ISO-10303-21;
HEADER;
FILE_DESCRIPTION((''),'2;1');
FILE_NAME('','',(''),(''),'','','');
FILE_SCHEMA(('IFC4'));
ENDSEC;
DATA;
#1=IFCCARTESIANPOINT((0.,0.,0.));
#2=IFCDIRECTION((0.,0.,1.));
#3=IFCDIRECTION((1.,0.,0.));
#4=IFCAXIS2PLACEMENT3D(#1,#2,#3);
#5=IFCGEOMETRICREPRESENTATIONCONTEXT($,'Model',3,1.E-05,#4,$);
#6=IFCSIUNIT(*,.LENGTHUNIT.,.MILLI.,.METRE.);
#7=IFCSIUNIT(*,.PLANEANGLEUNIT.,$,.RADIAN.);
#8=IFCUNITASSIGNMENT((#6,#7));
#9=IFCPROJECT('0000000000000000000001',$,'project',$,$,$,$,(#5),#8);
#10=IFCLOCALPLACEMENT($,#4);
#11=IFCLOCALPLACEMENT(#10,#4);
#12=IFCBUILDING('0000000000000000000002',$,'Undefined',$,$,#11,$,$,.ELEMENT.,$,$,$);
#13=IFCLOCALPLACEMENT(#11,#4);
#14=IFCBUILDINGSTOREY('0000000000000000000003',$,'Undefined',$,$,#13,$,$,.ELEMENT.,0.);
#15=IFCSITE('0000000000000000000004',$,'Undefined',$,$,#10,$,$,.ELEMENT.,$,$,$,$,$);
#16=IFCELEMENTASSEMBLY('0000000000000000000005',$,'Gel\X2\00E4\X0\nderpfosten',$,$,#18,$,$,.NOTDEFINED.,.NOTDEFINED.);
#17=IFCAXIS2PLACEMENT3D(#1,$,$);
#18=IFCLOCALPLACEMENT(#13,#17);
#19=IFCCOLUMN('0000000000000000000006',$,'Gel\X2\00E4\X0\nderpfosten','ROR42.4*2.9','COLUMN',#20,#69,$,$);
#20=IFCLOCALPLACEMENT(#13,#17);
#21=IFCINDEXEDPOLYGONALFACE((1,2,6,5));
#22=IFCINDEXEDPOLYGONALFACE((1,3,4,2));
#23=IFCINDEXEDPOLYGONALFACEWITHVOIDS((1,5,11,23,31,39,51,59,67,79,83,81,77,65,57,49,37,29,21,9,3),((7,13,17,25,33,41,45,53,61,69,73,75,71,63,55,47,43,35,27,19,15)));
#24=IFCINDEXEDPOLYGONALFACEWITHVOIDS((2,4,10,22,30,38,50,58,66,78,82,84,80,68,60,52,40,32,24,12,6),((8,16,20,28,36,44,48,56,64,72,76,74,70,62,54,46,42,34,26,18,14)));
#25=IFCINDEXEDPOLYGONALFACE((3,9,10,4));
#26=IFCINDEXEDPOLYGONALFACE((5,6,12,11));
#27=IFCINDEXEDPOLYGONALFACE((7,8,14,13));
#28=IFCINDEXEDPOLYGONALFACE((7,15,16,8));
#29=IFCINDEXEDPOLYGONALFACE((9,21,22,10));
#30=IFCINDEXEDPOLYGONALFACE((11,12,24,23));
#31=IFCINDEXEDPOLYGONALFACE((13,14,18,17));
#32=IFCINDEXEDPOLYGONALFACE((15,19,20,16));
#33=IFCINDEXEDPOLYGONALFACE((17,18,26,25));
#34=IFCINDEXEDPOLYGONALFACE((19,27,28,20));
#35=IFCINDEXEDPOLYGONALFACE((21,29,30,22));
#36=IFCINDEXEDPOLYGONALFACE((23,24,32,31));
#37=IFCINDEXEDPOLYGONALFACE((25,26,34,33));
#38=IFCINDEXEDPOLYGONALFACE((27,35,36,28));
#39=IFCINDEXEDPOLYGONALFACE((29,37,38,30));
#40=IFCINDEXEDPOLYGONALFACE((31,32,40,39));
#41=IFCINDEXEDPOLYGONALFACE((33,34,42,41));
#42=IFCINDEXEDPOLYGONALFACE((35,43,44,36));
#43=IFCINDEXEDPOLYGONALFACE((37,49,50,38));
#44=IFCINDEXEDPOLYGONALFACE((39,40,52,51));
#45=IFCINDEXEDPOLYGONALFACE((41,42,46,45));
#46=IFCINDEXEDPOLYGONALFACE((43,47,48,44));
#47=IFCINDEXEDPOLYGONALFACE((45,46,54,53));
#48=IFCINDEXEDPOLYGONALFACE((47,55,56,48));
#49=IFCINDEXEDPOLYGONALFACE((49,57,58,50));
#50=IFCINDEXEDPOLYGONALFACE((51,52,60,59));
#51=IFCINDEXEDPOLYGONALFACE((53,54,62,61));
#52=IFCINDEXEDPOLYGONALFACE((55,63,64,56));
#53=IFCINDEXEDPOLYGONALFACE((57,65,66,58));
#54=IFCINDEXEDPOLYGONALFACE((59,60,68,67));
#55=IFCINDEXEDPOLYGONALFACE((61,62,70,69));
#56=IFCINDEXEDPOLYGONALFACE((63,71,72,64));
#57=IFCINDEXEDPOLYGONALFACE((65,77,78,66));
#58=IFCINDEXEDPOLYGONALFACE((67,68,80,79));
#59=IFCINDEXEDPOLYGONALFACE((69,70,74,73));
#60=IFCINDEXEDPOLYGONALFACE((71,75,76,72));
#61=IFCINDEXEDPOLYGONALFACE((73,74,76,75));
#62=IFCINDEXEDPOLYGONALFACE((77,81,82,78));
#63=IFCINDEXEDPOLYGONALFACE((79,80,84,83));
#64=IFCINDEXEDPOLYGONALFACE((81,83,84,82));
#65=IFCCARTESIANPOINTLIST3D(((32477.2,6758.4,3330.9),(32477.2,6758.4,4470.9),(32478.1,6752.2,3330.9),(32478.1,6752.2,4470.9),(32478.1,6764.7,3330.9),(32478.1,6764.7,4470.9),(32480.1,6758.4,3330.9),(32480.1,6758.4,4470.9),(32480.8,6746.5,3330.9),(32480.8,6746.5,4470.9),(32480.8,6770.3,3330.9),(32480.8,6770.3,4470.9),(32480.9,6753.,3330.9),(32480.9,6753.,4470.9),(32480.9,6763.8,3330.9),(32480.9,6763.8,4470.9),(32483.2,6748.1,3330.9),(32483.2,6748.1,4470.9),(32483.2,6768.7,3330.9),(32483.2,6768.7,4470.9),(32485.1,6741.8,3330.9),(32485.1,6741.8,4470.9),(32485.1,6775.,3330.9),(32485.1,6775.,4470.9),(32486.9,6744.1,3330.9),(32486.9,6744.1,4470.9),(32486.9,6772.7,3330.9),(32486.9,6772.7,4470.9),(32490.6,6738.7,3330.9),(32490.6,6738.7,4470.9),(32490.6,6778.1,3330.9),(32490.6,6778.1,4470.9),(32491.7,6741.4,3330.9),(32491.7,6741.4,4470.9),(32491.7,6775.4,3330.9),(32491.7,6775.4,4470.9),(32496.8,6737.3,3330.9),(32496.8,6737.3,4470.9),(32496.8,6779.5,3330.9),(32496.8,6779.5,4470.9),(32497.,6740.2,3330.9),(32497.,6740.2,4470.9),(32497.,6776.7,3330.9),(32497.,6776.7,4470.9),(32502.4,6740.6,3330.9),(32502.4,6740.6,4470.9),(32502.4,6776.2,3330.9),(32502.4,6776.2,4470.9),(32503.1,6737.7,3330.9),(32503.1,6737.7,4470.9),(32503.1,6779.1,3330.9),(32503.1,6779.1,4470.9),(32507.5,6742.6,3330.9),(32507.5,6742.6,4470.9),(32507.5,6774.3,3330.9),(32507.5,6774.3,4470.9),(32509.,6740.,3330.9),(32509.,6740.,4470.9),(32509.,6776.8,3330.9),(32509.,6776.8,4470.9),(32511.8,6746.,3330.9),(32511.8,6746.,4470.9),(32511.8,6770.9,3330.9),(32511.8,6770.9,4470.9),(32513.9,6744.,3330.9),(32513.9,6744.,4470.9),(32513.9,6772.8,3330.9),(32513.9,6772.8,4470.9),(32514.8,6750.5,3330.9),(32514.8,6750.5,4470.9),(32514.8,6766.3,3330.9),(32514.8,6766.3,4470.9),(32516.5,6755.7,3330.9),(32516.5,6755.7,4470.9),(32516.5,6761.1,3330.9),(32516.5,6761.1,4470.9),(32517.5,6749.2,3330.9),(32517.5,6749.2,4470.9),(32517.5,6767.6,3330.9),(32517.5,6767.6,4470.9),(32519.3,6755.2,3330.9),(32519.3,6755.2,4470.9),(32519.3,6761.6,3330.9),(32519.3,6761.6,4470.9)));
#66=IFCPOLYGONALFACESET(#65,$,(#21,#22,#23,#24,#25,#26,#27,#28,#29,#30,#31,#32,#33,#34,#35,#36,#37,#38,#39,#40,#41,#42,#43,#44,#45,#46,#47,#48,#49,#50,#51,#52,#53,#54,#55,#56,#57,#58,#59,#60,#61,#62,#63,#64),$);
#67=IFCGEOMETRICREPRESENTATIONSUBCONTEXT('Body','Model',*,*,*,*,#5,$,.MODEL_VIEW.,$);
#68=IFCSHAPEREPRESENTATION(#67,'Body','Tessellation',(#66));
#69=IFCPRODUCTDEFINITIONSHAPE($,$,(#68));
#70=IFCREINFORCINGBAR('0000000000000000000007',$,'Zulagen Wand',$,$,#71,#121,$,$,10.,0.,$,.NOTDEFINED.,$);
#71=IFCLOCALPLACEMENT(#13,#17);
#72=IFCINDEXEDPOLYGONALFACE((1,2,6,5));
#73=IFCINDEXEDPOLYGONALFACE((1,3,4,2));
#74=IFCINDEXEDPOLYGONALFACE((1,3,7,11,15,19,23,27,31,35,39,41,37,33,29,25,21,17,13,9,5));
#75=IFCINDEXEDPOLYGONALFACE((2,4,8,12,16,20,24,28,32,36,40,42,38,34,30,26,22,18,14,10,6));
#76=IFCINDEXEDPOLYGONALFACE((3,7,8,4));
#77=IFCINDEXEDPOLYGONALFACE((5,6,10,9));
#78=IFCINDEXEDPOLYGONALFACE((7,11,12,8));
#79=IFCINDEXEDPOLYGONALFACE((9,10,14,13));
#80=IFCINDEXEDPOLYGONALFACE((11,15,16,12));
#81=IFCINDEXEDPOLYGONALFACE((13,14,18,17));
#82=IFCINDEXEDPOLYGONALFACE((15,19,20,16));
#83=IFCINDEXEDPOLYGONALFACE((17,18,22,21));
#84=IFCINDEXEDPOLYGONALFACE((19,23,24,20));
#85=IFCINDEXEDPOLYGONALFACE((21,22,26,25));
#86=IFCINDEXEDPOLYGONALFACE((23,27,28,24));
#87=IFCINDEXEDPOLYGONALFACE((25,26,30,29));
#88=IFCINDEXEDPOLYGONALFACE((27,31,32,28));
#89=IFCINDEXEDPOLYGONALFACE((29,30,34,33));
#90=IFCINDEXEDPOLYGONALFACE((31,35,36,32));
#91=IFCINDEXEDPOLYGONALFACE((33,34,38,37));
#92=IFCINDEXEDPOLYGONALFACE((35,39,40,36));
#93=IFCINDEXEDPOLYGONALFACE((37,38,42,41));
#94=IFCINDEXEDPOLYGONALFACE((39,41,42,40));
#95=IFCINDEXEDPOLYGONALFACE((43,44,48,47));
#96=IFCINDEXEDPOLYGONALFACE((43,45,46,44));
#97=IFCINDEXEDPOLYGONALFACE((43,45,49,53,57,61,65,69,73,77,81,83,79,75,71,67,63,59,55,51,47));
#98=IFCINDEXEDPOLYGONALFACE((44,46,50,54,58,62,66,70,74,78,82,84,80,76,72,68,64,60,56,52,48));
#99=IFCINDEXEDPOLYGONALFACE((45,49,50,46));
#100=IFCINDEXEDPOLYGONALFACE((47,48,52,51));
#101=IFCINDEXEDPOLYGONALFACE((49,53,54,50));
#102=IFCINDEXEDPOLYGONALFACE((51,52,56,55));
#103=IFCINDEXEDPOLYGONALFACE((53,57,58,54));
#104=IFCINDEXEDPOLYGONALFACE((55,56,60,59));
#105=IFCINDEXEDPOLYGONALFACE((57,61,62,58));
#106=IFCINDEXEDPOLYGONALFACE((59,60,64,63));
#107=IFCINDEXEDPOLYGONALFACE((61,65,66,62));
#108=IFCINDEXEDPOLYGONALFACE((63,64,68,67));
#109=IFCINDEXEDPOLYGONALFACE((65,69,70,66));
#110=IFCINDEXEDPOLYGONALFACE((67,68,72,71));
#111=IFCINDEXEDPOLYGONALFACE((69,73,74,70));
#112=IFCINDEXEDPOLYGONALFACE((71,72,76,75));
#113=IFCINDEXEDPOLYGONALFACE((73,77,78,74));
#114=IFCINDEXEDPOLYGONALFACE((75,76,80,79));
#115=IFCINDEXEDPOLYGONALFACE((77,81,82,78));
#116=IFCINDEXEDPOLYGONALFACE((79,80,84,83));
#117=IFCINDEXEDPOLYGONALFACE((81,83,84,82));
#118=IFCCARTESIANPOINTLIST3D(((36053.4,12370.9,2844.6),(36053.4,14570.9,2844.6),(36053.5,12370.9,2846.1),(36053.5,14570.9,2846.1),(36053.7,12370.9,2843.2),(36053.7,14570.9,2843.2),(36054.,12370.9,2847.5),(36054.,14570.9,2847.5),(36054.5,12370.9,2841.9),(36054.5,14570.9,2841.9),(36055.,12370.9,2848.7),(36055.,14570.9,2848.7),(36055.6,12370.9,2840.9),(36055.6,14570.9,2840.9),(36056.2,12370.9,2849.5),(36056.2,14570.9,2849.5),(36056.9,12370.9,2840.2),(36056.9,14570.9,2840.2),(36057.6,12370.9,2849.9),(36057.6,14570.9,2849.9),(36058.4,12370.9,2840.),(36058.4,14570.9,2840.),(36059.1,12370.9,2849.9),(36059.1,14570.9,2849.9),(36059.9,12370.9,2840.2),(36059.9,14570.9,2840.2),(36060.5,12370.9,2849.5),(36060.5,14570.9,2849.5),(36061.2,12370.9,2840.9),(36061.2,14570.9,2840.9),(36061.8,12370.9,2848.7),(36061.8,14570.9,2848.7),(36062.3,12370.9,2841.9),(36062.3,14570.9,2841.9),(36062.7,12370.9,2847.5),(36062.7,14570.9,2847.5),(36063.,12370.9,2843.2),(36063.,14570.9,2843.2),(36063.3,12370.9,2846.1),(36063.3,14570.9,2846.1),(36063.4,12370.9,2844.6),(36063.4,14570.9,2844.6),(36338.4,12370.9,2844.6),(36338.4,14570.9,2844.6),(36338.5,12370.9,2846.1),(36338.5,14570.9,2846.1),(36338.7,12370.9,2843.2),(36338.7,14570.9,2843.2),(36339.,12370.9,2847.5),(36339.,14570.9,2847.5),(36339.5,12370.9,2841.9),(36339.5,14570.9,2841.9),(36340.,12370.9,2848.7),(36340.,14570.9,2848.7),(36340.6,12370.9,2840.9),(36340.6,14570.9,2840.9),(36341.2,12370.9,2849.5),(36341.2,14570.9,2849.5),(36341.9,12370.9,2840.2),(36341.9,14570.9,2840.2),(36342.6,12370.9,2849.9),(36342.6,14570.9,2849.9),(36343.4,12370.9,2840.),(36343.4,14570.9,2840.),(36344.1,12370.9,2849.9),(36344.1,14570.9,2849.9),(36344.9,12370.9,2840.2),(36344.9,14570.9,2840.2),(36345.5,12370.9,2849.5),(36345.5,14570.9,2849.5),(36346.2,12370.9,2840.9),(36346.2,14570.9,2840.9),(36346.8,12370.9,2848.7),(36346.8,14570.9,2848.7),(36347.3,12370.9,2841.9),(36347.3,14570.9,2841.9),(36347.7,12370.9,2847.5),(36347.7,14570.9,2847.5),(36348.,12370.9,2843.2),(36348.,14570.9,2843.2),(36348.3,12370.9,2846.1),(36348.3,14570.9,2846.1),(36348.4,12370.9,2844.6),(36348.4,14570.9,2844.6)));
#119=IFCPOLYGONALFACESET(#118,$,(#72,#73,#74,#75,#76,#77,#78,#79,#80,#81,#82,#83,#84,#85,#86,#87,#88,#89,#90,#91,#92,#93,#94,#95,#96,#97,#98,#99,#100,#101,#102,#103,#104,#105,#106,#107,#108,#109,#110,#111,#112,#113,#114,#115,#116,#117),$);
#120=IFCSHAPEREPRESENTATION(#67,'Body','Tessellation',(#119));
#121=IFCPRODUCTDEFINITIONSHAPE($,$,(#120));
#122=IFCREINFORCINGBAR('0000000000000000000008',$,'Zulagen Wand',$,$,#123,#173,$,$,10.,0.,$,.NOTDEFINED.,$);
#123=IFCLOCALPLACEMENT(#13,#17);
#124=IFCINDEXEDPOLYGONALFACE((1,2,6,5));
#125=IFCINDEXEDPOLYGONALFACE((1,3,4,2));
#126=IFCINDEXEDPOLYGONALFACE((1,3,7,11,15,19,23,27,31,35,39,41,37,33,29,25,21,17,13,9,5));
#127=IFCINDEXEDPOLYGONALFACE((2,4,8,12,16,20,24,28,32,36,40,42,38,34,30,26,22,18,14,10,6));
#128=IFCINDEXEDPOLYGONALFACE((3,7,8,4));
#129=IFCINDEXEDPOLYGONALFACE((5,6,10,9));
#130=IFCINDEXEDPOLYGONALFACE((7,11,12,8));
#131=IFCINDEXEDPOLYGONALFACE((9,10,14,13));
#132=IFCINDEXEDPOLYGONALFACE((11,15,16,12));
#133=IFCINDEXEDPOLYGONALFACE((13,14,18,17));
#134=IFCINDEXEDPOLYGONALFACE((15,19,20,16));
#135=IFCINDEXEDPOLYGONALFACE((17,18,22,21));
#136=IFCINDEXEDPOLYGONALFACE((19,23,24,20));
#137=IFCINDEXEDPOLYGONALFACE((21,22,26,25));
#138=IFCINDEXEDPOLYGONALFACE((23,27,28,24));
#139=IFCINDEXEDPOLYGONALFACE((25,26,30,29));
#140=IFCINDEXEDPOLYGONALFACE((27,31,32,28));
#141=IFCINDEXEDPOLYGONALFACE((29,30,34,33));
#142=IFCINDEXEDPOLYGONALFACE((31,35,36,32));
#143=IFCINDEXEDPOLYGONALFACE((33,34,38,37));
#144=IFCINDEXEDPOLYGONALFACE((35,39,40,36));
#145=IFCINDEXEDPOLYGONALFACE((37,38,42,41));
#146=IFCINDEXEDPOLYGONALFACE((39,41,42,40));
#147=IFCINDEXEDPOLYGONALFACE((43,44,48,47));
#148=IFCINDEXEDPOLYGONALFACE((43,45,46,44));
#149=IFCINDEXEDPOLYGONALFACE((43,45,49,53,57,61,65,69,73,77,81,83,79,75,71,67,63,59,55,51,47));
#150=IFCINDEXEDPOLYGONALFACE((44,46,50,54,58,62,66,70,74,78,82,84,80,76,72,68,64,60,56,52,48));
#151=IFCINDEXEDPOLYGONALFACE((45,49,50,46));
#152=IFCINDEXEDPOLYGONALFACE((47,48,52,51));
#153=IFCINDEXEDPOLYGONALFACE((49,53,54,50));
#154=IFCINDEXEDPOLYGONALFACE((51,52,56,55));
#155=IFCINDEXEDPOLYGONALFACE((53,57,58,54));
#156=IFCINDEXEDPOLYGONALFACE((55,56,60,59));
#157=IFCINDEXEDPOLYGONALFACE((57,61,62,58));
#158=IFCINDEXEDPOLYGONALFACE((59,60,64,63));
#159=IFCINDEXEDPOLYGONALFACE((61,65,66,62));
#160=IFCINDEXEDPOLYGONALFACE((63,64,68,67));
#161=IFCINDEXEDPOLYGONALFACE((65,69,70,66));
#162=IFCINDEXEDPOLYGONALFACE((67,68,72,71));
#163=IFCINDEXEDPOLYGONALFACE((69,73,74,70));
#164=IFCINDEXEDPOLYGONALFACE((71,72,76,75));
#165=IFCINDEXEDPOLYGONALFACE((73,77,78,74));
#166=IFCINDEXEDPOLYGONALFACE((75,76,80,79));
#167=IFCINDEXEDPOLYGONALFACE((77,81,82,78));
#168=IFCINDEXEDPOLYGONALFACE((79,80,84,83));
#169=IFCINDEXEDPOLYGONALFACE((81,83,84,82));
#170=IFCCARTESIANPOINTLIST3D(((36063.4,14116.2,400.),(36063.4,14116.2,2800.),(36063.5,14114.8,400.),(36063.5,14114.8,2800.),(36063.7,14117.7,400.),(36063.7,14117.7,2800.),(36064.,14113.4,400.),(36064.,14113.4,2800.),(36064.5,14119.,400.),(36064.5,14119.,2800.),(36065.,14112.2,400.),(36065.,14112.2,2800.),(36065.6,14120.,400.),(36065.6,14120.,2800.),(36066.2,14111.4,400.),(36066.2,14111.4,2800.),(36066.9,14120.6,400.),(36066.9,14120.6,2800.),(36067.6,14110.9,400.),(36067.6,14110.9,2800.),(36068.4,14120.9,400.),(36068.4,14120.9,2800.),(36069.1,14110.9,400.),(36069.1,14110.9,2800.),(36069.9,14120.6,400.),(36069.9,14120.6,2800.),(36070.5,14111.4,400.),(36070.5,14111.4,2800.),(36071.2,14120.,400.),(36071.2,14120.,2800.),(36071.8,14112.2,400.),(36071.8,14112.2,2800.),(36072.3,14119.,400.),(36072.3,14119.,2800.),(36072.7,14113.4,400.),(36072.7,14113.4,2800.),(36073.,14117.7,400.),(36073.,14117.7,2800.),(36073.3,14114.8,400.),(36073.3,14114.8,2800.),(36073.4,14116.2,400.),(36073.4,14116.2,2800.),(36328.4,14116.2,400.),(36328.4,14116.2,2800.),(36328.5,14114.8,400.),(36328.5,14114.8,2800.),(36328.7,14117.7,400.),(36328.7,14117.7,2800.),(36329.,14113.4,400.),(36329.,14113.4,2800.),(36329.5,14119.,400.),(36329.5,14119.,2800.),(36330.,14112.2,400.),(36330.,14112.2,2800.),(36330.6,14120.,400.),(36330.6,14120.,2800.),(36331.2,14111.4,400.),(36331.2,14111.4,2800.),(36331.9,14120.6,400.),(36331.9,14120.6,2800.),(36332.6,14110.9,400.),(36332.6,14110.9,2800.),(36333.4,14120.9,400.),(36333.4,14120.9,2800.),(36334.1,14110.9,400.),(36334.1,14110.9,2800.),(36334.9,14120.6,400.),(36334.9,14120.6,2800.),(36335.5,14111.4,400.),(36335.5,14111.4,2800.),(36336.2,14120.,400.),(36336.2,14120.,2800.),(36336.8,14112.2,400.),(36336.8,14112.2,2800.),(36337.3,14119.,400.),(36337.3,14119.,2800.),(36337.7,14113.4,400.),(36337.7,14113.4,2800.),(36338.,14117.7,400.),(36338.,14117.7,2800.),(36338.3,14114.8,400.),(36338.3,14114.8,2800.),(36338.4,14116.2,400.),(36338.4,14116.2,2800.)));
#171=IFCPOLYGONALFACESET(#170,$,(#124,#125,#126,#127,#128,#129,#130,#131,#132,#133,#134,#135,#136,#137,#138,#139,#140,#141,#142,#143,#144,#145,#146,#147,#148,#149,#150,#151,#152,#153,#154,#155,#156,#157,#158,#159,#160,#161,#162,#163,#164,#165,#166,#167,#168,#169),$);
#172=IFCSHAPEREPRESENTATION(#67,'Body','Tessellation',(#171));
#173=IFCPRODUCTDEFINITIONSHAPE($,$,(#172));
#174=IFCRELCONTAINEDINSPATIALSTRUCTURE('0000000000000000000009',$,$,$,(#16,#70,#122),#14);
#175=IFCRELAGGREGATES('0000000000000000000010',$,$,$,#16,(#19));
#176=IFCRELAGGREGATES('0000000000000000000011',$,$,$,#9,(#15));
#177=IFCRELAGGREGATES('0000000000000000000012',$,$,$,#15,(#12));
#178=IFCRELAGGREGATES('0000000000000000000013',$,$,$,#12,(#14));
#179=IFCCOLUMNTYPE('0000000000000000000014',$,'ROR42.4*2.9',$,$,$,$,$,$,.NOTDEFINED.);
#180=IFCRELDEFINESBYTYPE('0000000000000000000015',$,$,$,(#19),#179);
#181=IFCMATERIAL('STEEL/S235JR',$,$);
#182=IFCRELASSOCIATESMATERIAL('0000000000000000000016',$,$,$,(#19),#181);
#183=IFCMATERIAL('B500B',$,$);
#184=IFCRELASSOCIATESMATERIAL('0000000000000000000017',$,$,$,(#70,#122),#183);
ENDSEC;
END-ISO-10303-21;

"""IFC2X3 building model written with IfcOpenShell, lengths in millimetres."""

from ifc_helpers import new_model, entity, si_unit, frame, origin_with_axes, origin_2d_with_axis, place, context, subcontext, project, spatial, hollow_circle, extrude, source, transform, mapped, material, type_object, element, aggregate, save


model = new_model("IFC2X3")

# Units and contexts
model_context = context("Model", 3, precision=1e-05, world=origin_with_axes())
body_context = subcontext(model_context, "Body", "Model", "MODEL_VIEW")
ifc_project = project(units=[si_unit("LENGTHUNIT", "METRE", prefix="MILLI"), si_unit("PLANEANGLEUNIT", "RADIAN")], contexts=[model_context])

# Site, building, storey
site_placement = place(None, origin_with_axes())
site = spatial("IfcSite", under=ifc_project, at=site_placement, Name="Undefined", CompositionType="ELEMENT")
building_placement = place(site_placement, origin_with_axes())
building = spatial("IfcBuilding", under=site, at=building_placement, Name="Undefined", CompositionType="ELEMENT")
storey_placement = place(building_placement, origin_with_axes())
storey = spatial("IfcBuildingStorey", under=building, at=storey_placement, Name="Undefined", CompositionType="ELEMENT", Elevation=0.0)

# Element assembly, column
assembly_1_placement = place(storey_placement, origin_with_axes())
assembly_1 = element("IfcElementAssembly", 1, at=assembly_1_placement, inside=storey, Name="Geländerpfosten", AssemblyPlace="NOTDEFINED", PredefinedType="NOTDEFINED")
ifc_material_1 = material(Name="STEEL/S235JR")
column_type = type_object("IfcColumnType", Name="ROR42.4*2.9", PredefinedType="NOTDEFINED")
column_placement = place(assembly_1_placement, frame((32498.4, 6758.4, 3330.9), z_axis=(0.0, 0.0, 1.0), x_axis=(0.0, 1.0, 0.0)))
column = element("IfcColumn", 2, at=column_placement, type_object=column_type, material=ifc_material_1, Name="Geländerpfosten", Description="ROR42.4*2.9", ObjectType="COLUMN", context=body_context, shape_type="SweptSolid", body=[
    extrude(hollow_circle(Radius=21.2, WallThickness=2.9, at=origin_2d_with_axis()), frame((0.0, 0.0, 1140.0), z_axis=(0.0, 0.0, -1.0), x_axis=(0.0, 1.0, 0.0)), (0.0, 0.0, 1.0), 1140.0),
])
aggregate(assembly_1, [column])

# Reinforcing bars
ifc_material_2 = material(Name="B500B")
shared_shape_1 = source(origin_with_axes(), body_context, "Body", "AdvancedSweptSolid", [
    entity("IfcSweptDiskSolid", entity("IfcTrimmedCurve", entity("IfcLine", entity("IfcCartesianPoint", [0.0, 0.0, 0.0]), entity("IfcVector", entity("IfcDirection", [1.0, 0.0, 0.0]), 1.0)), [entity("IfcParameterValue", 0.0)], [entity("IfcParameterValue", 2200.0)], True, "PARAMETER"), 5.0, None, 0.0, 2200.0),
])
shared_shape_2 = source(origin_with_axes(), body_context, "Body", "AdvancedSweptSolid", [
    entity("IfcSweptDiskSolid", entity("IfcTrimmedCurve", entity("IfcLine", entity("IfcCartesianPoint", [0.0, 0.0, 0.0]), entity("IfcVector", entity("IfcDirection", [1.0, 0.0, 0.0]), 1.0)), [entity("IfcParameterValue", 0.0)], [entity("IfcParameterValue", 2200.0)], True, "PARAMETER"), 5.0, None, 0.0, 2200.0),
])
reinforcing_bar_1_placement = place(storey_placement, frame((36058.4, 12370.9, 2845.0), z_axis=(0.0, 0.0, -1.0), x_axis=(0.0, 1.0, 0.0)))
element("IfcReinforcingBar", 3, at=reinforcing_bar_1_placement, inside=storey, material=ifc_material_2, Name="Zulagen Wand", BarRole="NOTDEFINED", CrossSectionArea=0.0, NominalDiameter=10.0, context=body_context, shape_type="MappedRepresentation", body=[
    mapped(shared_shape_1, transform((0.0, 0.0, 0.0))),
    mapped(shared_shape_2, transform((0.0, 285.0, 0.0))),
])
shared_shape_3 = source(origin_with_axes(), body_context, "Body", "AdvancedSweptSolid", [
    entity("IfcSweptDiskSolid", entity("IfcTrimmedCurve", entity("IfcLine", entity("IfcCartesianPoint", [0.0, 0.0, 0.0]), entity("IfcVector", entity("IfcDirection", [1.0, 0.0, 0.0]), 1.0)), [entity("IfcParameterValue", 0.0)], [entity("IfcParameterValue", 2400.0)], True, "PARAMETER"), 5.0, None, 0.0, 2400.0),
])
shared_shape_4 = source(origin_with_axes(), body_context, "Body", "AdvancedSweptSolid", [
    entity("IfcSweptDiskSolid", entity("IfcTrimmedCurve", entity("IfcLine", entity("IfcCartesianPoint", [0.0, 0.0, 0.0]), entity("IfcVector", entity("IfcDirection", [1.0, 0.0, 0.0]), 1.0)), [entity("IfcParameterValue", 0.0)], [entity("IfcParameterValue", 2400.0)], True, "PARAMETER"), 5.0, None, 0.0, 2400.0),
])
reinforcing_bar_2_placement = place(storey_placement, frame((36068.4, 14115.9, 400.0), z_axis=(0.0, 1.0, 0.0), x_axis=(0.0, 0.0, 1.0)))
element("IfcReinforcingBar", 4, at=reinforcing_bar_2_placement, inside=storey, material=ifc_material_2, Name="Zulagen Wand", BarRole="NOTDEFINED", CrossSectionArea=0.0, NominalDiameter=10.0, context=body_context, shape_type="MappedRepresentation", body=[
    mapped(shared_shape_3, transform((0.0, 0.0, 0.0))),
    mapped(shared_shape_4, transform((0.0, 265.0, 0.0))),
])

save(model, "model.ifc")
